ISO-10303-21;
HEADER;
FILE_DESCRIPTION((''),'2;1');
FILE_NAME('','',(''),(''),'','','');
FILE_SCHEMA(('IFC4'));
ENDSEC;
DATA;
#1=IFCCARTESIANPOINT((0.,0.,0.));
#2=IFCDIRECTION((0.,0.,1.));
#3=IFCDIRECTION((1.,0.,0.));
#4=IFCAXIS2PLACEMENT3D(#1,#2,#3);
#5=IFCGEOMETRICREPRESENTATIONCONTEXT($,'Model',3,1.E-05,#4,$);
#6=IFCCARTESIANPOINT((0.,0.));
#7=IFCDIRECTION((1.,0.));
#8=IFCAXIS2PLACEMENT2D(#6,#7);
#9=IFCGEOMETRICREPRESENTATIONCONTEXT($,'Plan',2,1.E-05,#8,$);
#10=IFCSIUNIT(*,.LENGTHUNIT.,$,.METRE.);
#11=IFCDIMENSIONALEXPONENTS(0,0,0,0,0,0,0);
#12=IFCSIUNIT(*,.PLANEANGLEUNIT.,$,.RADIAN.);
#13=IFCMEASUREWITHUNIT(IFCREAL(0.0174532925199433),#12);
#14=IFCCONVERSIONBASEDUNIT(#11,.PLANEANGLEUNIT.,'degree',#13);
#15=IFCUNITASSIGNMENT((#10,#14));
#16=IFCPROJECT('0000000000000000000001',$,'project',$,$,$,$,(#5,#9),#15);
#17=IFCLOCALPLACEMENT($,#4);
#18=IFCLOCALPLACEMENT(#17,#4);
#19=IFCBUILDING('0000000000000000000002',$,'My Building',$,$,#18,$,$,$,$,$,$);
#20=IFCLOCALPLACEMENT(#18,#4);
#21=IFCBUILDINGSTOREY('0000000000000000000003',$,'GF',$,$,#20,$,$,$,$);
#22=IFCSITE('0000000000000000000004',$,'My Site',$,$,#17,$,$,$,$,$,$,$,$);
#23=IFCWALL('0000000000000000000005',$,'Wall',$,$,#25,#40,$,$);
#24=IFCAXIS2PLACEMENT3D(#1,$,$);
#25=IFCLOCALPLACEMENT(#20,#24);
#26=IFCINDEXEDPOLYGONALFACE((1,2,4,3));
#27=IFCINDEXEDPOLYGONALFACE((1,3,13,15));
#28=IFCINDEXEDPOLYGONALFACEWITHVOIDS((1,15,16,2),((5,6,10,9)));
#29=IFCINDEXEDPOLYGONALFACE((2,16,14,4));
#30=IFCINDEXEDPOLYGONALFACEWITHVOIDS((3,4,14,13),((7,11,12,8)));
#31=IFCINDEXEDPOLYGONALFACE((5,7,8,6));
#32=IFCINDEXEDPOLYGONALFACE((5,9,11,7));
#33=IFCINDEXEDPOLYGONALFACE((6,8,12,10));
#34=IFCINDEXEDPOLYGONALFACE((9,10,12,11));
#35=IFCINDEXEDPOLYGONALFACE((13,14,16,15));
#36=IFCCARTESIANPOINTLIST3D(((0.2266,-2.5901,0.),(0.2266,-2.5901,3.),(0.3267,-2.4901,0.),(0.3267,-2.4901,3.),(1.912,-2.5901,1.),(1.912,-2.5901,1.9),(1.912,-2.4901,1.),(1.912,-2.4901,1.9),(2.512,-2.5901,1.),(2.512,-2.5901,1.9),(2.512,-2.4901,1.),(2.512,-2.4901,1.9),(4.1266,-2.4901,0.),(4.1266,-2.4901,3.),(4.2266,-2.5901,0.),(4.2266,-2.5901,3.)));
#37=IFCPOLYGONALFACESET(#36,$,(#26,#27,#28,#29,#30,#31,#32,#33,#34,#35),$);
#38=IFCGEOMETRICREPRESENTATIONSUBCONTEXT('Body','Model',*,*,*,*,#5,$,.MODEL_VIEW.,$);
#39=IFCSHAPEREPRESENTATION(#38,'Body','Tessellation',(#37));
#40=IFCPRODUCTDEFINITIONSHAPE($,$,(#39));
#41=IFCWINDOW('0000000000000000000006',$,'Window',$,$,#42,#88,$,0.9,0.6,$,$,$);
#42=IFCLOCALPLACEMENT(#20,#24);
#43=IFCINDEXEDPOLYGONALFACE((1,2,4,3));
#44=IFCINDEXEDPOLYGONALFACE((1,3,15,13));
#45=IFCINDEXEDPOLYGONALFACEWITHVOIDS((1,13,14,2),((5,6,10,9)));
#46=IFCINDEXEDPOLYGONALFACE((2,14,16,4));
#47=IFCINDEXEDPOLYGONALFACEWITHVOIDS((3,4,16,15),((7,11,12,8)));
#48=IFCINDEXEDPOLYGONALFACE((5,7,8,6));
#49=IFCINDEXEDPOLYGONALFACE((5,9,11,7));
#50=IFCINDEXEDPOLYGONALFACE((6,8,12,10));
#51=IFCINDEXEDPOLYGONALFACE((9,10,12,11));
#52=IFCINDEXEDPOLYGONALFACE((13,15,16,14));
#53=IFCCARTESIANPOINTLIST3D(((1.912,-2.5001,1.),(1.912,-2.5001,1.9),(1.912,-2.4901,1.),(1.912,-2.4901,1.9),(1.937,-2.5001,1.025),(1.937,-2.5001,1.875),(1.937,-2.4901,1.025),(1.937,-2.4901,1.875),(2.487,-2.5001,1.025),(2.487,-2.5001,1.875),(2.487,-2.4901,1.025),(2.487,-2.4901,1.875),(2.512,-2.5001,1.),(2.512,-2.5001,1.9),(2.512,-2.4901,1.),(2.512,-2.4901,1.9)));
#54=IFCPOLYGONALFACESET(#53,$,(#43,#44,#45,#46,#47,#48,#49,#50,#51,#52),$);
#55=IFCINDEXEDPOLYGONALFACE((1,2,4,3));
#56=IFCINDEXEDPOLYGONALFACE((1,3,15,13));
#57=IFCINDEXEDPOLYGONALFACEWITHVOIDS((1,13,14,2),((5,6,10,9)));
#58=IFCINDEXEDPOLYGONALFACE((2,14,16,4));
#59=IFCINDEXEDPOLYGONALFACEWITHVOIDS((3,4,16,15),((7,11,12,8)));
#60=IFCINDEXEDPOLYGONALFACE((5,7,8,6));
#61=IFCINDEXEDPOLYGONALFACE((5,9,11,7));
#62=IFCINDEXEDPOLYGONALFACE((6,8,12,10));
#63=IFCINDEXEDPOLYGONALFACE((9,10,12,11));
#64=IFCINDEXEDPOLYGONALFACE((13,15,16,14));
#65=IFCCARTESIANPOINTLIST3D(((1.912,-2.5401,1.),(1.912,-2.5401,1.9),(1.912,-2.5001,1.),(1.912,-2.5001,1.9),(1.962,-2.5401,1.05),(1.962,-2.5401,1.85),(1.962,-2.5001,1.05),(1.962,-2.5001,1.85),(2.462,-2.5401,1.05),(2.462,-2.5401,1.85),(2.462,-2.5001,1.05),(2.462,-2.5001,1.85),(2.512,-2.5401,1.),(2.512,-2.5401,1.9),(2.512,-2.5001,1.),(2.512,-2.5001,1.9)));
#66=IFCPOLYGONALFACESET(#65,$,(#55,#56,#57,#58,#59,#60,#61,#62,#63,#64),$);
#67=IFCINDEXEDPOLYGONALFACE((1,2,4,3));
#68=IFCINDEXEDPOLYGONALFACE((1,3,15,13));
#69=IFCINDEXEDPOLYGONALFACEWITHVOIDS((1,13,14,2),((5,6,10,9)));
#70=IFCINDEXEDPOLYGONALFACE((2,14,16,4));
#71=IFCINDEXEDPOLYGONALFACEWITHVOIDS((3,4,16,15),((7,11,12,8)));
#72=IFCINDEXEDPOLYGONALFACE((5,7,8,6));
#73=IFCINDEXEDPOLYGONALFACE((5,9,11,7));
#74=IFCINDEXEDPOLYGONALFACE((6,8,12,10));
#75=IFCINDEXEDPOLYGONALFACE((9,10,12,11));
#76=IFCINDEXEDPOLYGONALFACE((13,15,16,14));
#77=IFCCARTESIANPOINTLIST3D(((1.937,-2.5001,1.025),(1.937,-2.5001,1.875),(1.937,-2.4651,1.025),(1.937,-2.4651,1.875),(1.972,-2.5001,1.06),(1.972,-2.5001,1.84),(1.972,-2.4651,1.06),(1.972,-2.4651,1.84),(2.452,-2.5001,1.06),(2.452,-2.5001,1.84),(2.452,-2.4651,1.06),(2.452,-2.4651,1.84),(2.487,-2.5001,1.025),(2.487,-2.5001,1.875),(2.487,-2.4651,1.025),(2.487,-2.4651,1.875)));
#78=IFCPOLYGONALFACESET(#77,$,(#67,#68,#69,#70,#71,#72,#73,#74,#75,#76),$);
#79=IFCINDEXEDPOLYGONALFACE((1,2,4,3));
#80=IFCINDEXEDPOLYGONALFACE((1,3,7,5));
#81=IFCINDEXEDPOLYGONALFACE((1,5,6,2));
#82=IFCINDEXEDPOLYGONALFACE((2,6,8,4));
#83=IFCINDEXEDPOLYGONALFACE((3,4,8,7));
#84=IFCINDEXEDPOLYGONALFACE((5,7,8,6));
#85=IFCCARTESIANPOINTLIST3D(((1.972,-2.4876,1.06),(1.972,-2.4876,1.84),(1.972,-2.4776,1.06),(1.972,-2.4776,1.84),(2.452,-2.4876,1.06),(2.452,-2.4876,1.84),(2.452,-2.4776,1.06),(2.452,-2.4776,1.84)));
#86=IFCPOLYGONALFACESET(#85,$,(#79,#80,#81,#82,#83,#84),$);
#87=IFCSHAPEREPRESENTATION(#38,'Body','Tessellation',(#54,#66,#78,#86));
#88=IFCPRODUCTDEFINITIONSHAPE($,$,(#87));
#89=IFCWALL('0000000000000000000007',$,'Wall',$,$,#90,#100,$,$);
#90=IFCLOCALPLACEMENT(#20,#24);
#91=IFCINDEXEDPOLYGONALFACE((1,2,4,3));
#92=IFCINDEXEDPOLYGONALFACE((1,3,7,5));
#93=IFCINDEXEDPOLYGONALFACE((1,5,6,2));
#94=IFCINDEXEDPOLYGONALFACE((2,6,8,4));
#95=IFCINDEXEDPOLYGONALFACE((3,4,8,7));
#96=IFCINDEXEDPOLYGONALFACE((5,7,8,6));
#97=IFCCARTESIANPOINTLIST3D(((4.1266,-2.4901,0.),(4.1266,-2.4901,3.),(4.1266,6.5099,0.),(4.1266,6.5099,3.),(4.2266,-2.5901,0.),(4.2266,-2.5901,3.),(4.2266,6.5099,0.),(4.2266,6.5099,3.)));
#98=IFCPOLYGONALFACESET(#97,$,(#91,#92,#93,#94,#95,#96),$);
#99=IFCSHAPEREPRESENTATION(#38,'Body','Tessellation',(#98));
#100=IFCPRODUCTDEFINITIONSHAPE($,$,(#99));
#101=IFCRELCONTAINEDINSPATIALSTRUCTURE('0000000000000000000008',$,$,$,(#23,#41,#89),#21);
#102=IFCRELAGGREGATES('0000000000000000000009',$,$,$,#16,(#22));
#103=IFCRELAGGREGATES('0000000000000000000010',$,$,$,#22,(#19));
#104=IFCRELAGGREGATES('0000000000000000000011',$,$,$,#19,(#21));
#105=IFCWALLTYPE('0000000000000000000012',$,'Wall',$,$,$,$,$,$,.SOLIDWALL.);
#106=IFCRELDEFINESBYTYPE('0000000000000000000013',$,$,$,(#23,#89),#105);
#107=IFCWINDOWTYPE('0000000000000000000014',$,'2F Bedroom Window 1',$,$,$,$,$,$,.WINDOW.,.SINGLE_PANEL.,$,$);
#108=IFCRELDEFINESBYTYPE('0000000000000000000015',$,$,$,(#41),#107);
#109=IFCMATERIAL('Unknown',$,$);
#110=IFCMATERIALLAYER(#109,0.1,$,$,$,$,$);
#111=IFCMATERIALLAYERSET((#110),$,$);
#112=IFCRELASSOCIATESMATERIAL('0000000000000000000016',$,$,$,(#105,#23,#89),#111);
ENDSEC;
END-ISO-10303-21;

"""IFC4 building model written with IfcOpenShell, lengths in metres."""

from ifc_helpers import new_model, entity, si_unit, converted_unit, frame, origin_with_axes, origin_2d_with_axis, place, context, subcontext, project, spatial, line, indexed_curve, outline, extrude, shape, source, transform, mapped, material, layer, layer_set, layer_usage, type_object, type_shapes, element, fill, save


model = new_model("IFC4")

# Units and contexts
model_context = context("Model", 3, precision=1e-05, world=origin_with_axes())
plan_context = context("Plan", 2, precision=1e-05, world=origin_2d_with_axis())
body_context_1 = subcontext(model_context, "Body", "Model", "MODEL_VIEW")
body_context_2 = subcontext(plan_context, "Body", "Plan", "PLAN_VIEW")
ifc_project = project(units=[si_unit("LENGTHUNIT", "METRE"), converted_unit("PLANEANGLEUNIT", "degree", entity("IfcReal", 0.0174532925199433), si_unit("PLANEANGLEUNIT", "RADIAN"), dimensions=[0, 0, 0, 0, 0, 0, 0])], contexts=[model_context, plan_context])

# Site, building, storey
site_placement = place(None, origin_with_axes())
site = spatial("IfcSite", under=ifc_project, at=site_placement, Name="My Site")
building_placement = place(site_placement, origin_with_axes())
building = spatial("IfcBuilding", under=site, at=building_placement, Name="My Building")
storey_placement = place(building_placement, origin_with_axes())
storey = spatial("IfcBuildingStorey", under=building, at=storey_placement, Name="GF")

# Shared definitions
ifc_material_1 = material(Name="Unknown")

# Shared definitions
ifc_layer_1 = layer(ifc_material_1, 0.1)
ifc_layer_set_1 = layer_set([ifc_layer_1])
wall_type = type_object("IfcWallType", Name="Wall", PredefinedType="SOLIDWALL", material=ifc_layer_set_1)

# Wall, opening, window
ifc_layer_usage_1 = layer_usage(ifc_layer_set_1, "AXIS2", "POSITIVE", 0.0)
wall_1_placement = place(storey_placement, frame((0.2266, -2.5901, 0.0), z_axis=(0.0, 0.0, 1.0), x_axis=(1.0, 0.0, 0.0)))
wall_1 = element("IfcWall", 1, at=wall_1_placement, inside=storey, type_object=wall_type, material=ifc_layer_usage_1, Name="Wall", context=body_context_1, shape_type="SweptSolid", body=[
    extrude(outline(indexed_curve([(0.0, 0.0), (0.1001, 0.1), (3.9, 0.1), (4.0, 0.0)], segments=[line(1, 2, 3, 4, 1)])), origin_with_axes(), (0.0, 0.0, 1.0), 3.0),
])
shared_shape_1 = source(origin_with_axes(), body_context_1, "Body", "SweptSolid", [
    extrude(outline(indexed_curve([(0.0, 0.0), (0.6, 0.0), (0.6, 0.9), (0.0, 0.9)], segments=[line(1, 2, 3, 4, 1)])), frame((0.0, -0.6, 0.0), z_axis=(0.0, -1.0, 0.0), x_axis=(1.0, 0.0, 0.0)), (0.0, 0.0, -1.0), 1.2),
])
opening_1_placement = place(wall_1_placement, frame((1.6854, 0.0, 1.0), z_axis=(0.0, 0.0, 1.0), x_axis=(1.0, 0.0, 0.0)))
opening_1 = element("IfcOpeningElement", 2, at=opening_1_placement, cuts=wall_1, PredefinedType="OPENING", context=body_context_1, shape_type="MappedRepresentation", body=[
    mapped(shared_shape_1, transform((0.0, 0.0, 0.0), x_axis=(1.0, 0.0, 0.0), y_axis=(0.0, 1.0, 0.0), z_axis=(0.0, 0.0, 1.0), scale=1.0)),
])
window_type_1 = type_object("IfcWindowType", Name="2F Bedroom Window 1", PartitioningType="SINGLE_PANEL", PredefinedType="WINDOW")
shared_shape_2 = source(origin_with_axes(), body_context_1, "Body", "SweptSolid", [
    extrude(outline(indexed_curve([(0.0, 0.0), (0.6, 0.0), (0.6, 0.9), (0.0, 0.9)], segments=[line(1, 2, 3, 4, 1)]), holes=[indexed_curve([(0.025, 0.025), (0.575, 0.025), (0.575, 0.875), (0.025, 0.875)], segments=[line(1, 2, 3, 4, 1)])]), frame((0.0, 0.09, 0.0), z_axis=(0.0, -1.0, 0.0), x_axis=(1.0, 0.0, 0.0)), (0.0, 0.0, -1.0), 0.01),
    extrude(outline(indexed_curve([(0.0, 0.0), (0.6, 0.0), (0.6, 0.9), (0.0, 0.9)], segments=[line(1, 2, 3, 4, 1)]), holes=[indexed_curve([(0.05, 0.05), (0.55, 0.05), (0.55, 0.85), (0.05, 0.85)], segments=[line(1, 2, 3, 4, 1)])]), frame((0.0, 0.05, 0.0), z_axis=(0.0, -1.0, 0.0), x_axis=(1.0, 0.0, 0.0)), (0.0, 0.0, -1.0), 0.04),
    extrude(outline(indexed_curve([(0.0, 0.0), (0.55, 0.0), (0.55, 0.85), (0.0, 0.85)], segments=[line(1, 2, 3, 4, 1)]), holes=[indexed_curve([(0.035, 0.035), (0.515, 0.035), (0.515, 0.815), (0.035, 0.815)], segments=[line(1, 2, 3, 4, 1)])]), frame((0.025, 0.09, 0.025), z_axis=(0.0, -1.0, 0.0), x_axis=(1.0, 0.0, 0.0)), (0.0, 0.0, -1.0), 0.035),
    extrude(outline(indexed_curve([(0.035, 0.035), (0.515, 0.035), (0.515, 0.815), (0.035, 0.815)], segments=[line(1, 2, 3, 4, 1)])), frame((0.025, 0.1025, 0.025), z_axis=(0.0, -1.0, 0.0), x_axis=(1.0, 0.0, 0.0)), (0.0, 0.0, -1.0), 0.01),
])
shared_shape_3 = source(origin_with_axes(), body_context_2, "Body", "Curve2D", [
    entity("IfcIndexedPolyCurve", entity("IfcCartesianPointList2D", [[0.05, 0.05], [0.55, 0.05]])),
    entity("IfcIndexedPolyCurve", entity("IfcCartesianPointList2D", [[0.0, 0.1], [0.025, 0.1], [0.025, 0.09], [0.05, 0.09], [0.05, 0.05], [0.0, 0.05]]), [entity("IfcLineIndex", [1, 2, 3, 4, 5, 6, 1])]),
    entity("IfcIndexedPolyCurve", entity("IfcCartesianPointList2D", [[0.6, 0.1], [0.575, 0.1], [0.575, 0.09], [0.55, 0.09], [0.55, 0.05], [0.6, 0.05]]), [entity("IfcLineIndex", [1, 2, 3, 4, 5, 6, 1])]),
    entity("IfcIndexedPolyCurve", entity("IfcCartesianPointList2D", [[0.025, 0.09], [0.06, 0.09], [0.06, 0.125], [0.025, 0.125]]), [entity("IfcLineIndex", [1, 2, 3, 4, 1])]),
    entity("IfcIndexedPolyCurve", entity("IfcCartesianPointList2D", [[0.575, 0.09], [0.54, 0.09], [0.54, 0.125], [0.575, 0.125]]), [entity("IfcLineIndex", [1, 2, 3, 4, 1])]),
    entity("IfcIndexedPolyCurve", entity("IfcCartesianPointList2D", [[0.06, 0.09], [0.54, 0.09]])),
    entity("IfcIndexedPolyCurve", entity("IfcCartesianPointList2D", [[0.06, 0.125], [0.54, 0.125]])),
    entity("IfcIndexedPolyCurve", entity("IfcCartesianPointList2D", [[0.06, 0.1075], [0.54, 0.1075]])),
])
type_shapes(window_type_1, [shared_shape_2, shared_shape_3])
window_1_placement = place(opening_1_placement, origin_with_axes())
window_1 = element("IfcWindow", 3, at=window_1_placement, inside=storey, type_object=window_type_1, Name="Window", OverallHeight=0.9, OverallWidth=0.6, shapes=[
    shape(body_context_1, "Body", "MappedRepresentation", [mapped(shared_shape_2, transform((0.0, 0.0, 0.0), x_axis=(1.0, 0.0, 0.0), y_axis=(0.0, 1.0, 0.0), z_axis=(0.0, 0.0, 1.0), scale=1.0))]),
    shape(body_context_2, "Body", "MappedRepresentation", [mapped(shared_shape_3, transform((0.0, 0.0, 0.0), x_axis=(1.0, 0.0, 0.0), y_axis=(0.0, 1.0, 0.0), z_axis=(0.0, 0.0, 1.0), scale=1.0))]),
])
fill(opening_1, window_1)

# Wall
ifc_layer_usage_2 = layer_usage(ifc_layer_set_1, "AXIS2", "POSITIVE", 0.0)
wall_2_placement = place(storey_placement, frame((4.2266, -2.5901, 0.0), z_axis=(0.0, 0.0, 1.0), x_axis=(0.0, 1.0, 0.0)))
element("IfcWall", 4, at=wall_2_placement, inside=storey, type_object=wall_type, material=ifc_layer_usage_2, Name="Wall", context=body_context_1, shape_type="SweptSolid", body=[
    extrude(outline(indexed_curve([(0.0, 0.0), (0.1, 0.1), (9.1, 0.1), (9.1, 0.0)], segments=[line(1, 2, 3, 4, 1)])), origin_with_axes(), (0.0, 0.0, 1.0), 3.0),
])

save(model, "model.ifc")
